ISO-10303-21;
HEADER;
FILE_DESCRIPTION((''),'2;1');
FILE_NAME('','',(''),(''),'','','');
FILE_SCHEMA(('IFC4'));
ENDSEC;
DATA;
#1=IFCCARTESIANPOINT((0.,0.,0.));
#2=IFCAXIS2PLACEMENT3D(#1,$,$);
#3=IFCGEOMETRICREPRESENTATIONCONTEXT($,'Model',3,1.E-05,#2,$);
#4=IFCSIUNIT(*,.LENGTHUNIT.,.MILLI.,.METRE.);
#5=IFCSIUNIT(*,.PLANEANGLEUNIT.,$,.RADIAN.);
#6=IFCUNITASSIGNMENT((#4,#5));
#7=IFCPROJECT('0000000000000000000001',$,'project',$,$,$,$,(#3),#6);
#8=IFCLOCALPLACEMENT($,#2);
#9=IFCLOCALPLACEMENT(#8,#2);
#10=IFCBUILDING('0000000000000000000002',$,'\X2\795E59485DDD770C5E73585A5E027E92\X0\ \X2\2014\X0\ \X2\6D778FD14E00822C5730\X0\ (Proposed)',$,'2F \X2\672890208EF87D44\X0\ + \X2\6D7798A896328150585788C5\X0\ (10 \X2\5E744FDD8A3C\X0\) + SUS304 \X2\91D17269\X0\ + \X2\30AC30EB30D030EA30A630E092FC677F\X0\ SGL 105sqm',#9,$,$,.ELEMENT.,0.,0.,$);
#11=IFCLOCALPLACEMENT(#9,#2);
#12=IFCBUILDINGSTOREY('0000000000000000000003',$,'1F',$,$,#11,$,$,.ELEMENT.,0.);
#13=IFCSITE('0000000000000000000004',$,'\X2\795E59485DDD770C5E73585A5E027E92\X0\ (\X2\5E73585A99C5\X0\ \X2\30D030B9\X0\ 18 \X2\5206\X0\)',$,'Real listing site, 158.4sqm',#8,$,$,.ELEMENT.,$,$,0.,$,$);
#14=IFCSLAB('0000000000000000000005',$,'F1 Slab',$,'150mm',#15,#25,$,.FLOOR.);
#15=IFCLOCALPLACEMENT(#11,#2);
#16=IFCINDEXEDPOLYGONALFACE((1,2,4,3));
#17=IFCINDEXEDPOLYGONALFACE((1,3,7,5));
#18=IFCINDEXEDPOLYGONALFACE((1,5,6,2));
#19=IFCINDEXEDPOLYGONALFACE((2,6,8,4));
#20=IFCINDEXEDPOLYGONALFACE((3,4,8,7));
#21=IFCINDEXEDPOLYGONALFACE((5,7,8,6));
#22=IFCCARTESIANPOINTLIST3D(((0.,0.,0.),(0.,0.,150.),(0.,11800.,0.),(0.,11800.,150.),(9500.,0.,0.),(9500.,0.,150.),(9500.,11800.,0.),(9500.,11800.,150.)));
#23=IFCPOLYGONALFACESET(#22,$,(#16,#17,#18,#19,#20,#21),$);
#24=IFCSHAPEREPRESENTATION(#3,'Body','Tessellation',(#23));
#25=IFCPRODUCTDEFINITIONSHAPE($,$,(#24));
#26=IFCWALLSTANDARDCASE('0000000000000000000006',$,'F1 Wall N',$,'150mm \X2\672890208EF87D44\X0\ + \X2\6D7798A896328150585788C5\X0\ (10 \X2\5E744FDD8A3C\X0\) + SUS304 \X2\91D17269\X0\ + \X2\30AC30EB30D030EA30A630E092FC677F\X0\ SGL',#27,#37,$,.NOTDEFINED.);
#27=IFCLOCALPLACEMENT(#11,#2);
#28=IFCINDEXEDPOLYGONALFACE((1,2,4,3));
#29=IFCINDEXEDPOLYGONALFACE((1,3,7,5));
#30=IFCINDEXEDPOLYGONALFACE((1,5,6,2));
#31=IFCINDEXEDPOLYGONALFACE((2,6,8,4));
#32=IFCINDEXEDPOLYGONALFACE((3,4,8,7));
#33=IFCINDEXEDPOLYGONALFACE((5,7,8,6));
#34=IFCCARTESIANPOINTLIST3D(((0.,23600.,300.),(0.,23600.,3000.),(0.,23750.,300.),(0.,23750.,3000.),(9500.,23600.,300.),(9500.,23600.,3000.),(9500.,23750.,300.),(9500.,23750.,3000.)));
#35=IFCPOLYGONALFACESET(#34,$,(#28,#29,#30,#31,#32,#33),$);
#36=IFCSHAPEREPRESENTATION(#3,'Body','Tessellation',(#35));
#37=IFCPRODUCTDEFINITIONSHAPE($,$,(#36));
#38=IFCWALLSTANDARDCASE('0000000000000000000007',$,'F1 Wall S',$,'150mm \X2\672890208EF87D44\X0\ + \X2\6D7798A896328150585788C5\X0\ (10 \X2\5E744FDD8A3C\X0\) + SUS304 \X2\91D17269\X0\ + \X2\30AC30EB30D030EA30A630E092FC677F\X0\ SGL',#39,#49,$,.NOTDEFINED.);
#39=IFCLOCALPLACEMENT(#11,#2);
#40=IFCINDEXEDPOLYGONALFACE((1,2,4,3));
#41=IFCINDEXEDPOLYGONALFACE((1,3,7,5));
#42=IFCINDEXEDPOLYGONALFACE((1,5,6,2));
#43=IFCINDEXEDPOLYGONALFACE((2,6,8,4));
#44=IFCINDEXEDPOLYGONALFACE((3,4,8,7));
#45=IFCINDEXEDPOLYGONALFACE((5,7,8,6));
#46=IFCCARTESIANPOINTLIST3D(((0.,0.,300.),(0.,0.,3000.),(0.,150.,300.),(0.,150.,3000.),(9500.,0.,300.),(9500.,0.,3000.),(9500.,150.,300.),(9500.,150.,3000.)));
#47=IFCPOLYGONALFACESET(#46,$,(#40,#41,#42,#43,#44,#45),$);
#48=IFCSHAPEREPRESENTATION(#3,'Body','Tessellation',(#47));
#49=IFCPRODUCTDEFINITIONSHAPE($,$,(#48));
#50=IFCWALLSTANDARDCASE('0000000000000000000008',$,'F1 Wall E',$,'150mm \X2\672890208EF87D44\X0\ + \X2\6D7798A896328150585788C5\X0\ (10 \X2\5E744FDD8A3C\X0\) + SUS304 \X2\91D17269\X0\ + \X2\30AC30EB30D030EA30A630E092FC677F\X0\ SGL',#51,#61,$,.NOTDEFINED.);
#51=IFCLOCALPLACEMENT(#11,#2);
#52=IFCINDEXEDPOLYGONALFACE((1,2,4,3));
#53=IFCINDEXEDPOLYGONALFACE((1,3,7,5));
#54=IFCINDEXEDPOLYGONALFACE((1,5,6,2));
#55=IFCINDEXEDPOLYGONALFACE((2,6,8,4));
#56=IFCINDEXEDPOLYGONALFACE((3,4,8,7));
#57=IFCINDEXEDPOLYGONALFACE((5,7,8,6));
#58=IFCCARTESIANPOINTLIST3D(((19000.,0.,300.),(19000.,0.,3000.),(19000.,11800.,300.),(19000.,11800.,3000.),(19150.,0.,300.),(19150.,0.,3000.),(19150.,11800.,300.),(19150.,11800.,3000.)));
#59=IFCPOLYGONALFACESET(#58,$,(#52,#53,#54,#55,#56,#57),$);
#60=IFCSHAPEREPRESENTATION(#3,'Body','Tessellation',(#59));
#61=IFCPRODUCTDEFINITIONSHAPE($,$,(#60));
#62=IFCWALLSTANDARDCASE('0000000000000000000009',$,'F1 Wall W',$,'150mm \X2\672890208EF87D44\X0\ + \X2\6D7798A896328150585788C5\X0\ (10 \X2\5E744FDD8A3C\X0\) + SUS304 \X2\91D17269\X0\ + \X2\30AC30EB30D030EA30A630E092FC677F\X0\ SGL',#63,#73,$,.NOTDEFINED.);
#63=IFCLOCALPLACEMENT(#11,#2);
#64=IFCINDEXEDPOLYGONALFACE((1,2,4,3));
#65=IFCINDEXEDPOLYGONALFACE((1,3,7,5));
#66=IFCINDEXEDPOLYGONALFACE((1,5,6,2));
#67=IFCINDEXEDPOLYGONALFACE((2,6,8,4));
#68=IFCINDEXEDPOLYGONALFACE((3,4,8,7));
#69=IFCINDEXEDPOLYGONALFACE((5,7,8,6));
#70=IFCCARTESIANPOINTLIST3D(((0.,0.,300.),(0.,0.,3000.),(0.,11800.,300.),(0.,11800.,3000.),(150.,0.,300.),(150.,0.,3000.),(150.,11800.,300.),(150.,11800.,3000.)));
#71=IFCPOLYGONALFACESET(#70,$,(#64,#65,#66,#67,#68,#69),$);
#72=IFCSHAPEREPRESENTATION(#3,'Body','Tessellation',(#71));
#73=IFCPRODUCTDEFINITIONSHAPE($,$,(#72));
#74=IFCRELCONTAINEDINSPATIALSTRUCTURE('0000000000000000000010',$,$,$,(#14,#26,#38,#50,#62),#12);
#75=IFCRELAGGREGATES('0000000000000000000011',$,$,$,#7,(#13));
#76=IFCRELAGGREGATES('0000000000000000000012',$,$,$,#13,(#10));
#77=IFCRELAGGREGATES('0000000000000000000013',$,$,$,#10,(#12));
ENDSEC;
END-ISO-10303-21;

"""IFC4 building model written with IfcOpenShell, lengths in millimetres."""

from ifc_helpers import new_model, si_unit, frame, frame_2d, origin, place, context, project, spatial, rectangle, extrude, element, save


model = new_model("IFC4")

# Units and contexts
model_context = context("Model", 3, precision=1e-05, world=origin())
ifc_project = project(units=[si_unit("LENGTHUNIT", "METRE", prefix="MILLI"), si_unit("PLANEANGLEUNIT", "RADIAN")], contexts=[model_context])

# Site, building, storey
site_placement = place(None, origin())
site = spatial("IfcSite", under=ifc_project, at=site_placement, Name="神奈川県平塚市纒 (平塚駅 バス 18 分)", ObjectType="Real listing site, 158.4sqm", CompositionType="ELEMENT", RefElevation=0.0)
building_placement = place(site_placement, origin())
building = spatial("IfcBuilding", under=site, at=building_placement, Name="神奈川県平塚市纒 — 海近一般地 (Proposed)", ObjectType="2F 木造軸組 + 海風防腐塗装 (10 年保証) + SUS304 金物 + ガルバリウム鋼板 SGL 105sqm", CompositionType="ELEMENT", ElevationOfRefHeight=0.0, ElevationOfTerrain=0.0)
storey_placement = place(building_placement, origin())
storey = spatial("IfcBuildingStorey", under=building, at=storey_placement, Name="1F", CompositionType="ELEMENT", Elevation=0.0)

# Slab
slab_placement = place(storey_placement, origin())
element("IfcSlab", 1, at=slab_placement, inside=storey, Name="F1 Slab", ObjectType="150mm", PredefinedType="FLOOR", context=model_context, shape_type="SweptSolid", body=[
    extrude(rectangle(XDim=9500.0, YDim=11800.0, at=frame_2d((4750.0, 5900.0))), origin(), (0.0, 0.0, 1.0), 150.0),
])

# Walls
wall_1_placement = place(storey_placement, frame((0.0, 11800.0, 150.0)))
element("IfcWallStandardCase", 2, at=wall_1_placement, inside=storey, Name="F1 Wall N", ObjectType="150mm 木造軸組 + 海風防腐塗装 (10 年保証) + SUS304 金物 + ガルバリウム鋼板 SGL", PredefinedType="NOTDEFINED", context=model_context, shape_type="SweptSolid", body=[
    extrude(rectangle(XDim=9500.0, YDim=150.0, at=frame_2d((4750.0, 75.0))), frame((0.0, 11800.0, 150.0)), (0.0, 0.0, 1.0), 2700.0),
])
wall_2_placement = place(storey_placement, frame((0.0, 0.0, 150.0)))
element("IfcWallStandardCase", 3, at=wall_2_placement, inside=storey, Name="F1 Wall S", ObjectType="150mm 木造軸組 + 海風防腐塗装 (10 年保証) + SUS304 金物 + ガルバリウム鋼板 SGL", PredefinedType="NOTDEFINED", context=model_context, shape_type="SweptSolid", body=[
    extrude(rectangle(XDim=9500.0, YDim=150.0, at=frame_2d((4750.0, 75.0))), frame((0.0, 0.0, 150.0)), (0.0, 0.0, 1.0), 2700.0),
])
wall_3_placement = place(storey_placement, frame((9500.0, 0.0, 150.0)))
element("IfcWallStandardCase", 4, at=wall_3_placement, inside=storey, Name="F1 Wall E", ObjectType="150mm 木造軸組 + 海風防腐塗装 (10 年保証) + SUS304 金物 + ガルバリウム鋼板 SGL", PredefinedType="NOTDEFINED", context=model_context, shape_type="SweptSolid", body=[
    extrude(rectangle(XDim=150.0, YDim=11800.0, at=frame_2d((75.0, 5900.0))), frame((9500.0, 0.0, 150.0)), (0.0, 0.0, 1.0), 2700.0),
])
wall_4_placement = place(storey_placement, frame((0.0, 0.0, 150.0)))
element("IfcWallStandardCase", 5, at=wall_4_placement, inside=storey, Name="F1 Wall W", ObjectType="150mm 木造軸組 + 海風防腐塗装 (10 年保証) + SUS304 金物 + ガルバリウム鋼板 SGL", PredefinedType="NOTDEFINED", context=model_context, shape_type="SweptSolid", body=[
    extrude(rectangle(XDim=150.0, YDim=11800.0, at=frame_2d((75.0, 5900.0))), frame((0.0, 0.0, 150.0)), (0.0, 0.0, 1.0), 2700.0),
])

save(model, "model.ifc")
